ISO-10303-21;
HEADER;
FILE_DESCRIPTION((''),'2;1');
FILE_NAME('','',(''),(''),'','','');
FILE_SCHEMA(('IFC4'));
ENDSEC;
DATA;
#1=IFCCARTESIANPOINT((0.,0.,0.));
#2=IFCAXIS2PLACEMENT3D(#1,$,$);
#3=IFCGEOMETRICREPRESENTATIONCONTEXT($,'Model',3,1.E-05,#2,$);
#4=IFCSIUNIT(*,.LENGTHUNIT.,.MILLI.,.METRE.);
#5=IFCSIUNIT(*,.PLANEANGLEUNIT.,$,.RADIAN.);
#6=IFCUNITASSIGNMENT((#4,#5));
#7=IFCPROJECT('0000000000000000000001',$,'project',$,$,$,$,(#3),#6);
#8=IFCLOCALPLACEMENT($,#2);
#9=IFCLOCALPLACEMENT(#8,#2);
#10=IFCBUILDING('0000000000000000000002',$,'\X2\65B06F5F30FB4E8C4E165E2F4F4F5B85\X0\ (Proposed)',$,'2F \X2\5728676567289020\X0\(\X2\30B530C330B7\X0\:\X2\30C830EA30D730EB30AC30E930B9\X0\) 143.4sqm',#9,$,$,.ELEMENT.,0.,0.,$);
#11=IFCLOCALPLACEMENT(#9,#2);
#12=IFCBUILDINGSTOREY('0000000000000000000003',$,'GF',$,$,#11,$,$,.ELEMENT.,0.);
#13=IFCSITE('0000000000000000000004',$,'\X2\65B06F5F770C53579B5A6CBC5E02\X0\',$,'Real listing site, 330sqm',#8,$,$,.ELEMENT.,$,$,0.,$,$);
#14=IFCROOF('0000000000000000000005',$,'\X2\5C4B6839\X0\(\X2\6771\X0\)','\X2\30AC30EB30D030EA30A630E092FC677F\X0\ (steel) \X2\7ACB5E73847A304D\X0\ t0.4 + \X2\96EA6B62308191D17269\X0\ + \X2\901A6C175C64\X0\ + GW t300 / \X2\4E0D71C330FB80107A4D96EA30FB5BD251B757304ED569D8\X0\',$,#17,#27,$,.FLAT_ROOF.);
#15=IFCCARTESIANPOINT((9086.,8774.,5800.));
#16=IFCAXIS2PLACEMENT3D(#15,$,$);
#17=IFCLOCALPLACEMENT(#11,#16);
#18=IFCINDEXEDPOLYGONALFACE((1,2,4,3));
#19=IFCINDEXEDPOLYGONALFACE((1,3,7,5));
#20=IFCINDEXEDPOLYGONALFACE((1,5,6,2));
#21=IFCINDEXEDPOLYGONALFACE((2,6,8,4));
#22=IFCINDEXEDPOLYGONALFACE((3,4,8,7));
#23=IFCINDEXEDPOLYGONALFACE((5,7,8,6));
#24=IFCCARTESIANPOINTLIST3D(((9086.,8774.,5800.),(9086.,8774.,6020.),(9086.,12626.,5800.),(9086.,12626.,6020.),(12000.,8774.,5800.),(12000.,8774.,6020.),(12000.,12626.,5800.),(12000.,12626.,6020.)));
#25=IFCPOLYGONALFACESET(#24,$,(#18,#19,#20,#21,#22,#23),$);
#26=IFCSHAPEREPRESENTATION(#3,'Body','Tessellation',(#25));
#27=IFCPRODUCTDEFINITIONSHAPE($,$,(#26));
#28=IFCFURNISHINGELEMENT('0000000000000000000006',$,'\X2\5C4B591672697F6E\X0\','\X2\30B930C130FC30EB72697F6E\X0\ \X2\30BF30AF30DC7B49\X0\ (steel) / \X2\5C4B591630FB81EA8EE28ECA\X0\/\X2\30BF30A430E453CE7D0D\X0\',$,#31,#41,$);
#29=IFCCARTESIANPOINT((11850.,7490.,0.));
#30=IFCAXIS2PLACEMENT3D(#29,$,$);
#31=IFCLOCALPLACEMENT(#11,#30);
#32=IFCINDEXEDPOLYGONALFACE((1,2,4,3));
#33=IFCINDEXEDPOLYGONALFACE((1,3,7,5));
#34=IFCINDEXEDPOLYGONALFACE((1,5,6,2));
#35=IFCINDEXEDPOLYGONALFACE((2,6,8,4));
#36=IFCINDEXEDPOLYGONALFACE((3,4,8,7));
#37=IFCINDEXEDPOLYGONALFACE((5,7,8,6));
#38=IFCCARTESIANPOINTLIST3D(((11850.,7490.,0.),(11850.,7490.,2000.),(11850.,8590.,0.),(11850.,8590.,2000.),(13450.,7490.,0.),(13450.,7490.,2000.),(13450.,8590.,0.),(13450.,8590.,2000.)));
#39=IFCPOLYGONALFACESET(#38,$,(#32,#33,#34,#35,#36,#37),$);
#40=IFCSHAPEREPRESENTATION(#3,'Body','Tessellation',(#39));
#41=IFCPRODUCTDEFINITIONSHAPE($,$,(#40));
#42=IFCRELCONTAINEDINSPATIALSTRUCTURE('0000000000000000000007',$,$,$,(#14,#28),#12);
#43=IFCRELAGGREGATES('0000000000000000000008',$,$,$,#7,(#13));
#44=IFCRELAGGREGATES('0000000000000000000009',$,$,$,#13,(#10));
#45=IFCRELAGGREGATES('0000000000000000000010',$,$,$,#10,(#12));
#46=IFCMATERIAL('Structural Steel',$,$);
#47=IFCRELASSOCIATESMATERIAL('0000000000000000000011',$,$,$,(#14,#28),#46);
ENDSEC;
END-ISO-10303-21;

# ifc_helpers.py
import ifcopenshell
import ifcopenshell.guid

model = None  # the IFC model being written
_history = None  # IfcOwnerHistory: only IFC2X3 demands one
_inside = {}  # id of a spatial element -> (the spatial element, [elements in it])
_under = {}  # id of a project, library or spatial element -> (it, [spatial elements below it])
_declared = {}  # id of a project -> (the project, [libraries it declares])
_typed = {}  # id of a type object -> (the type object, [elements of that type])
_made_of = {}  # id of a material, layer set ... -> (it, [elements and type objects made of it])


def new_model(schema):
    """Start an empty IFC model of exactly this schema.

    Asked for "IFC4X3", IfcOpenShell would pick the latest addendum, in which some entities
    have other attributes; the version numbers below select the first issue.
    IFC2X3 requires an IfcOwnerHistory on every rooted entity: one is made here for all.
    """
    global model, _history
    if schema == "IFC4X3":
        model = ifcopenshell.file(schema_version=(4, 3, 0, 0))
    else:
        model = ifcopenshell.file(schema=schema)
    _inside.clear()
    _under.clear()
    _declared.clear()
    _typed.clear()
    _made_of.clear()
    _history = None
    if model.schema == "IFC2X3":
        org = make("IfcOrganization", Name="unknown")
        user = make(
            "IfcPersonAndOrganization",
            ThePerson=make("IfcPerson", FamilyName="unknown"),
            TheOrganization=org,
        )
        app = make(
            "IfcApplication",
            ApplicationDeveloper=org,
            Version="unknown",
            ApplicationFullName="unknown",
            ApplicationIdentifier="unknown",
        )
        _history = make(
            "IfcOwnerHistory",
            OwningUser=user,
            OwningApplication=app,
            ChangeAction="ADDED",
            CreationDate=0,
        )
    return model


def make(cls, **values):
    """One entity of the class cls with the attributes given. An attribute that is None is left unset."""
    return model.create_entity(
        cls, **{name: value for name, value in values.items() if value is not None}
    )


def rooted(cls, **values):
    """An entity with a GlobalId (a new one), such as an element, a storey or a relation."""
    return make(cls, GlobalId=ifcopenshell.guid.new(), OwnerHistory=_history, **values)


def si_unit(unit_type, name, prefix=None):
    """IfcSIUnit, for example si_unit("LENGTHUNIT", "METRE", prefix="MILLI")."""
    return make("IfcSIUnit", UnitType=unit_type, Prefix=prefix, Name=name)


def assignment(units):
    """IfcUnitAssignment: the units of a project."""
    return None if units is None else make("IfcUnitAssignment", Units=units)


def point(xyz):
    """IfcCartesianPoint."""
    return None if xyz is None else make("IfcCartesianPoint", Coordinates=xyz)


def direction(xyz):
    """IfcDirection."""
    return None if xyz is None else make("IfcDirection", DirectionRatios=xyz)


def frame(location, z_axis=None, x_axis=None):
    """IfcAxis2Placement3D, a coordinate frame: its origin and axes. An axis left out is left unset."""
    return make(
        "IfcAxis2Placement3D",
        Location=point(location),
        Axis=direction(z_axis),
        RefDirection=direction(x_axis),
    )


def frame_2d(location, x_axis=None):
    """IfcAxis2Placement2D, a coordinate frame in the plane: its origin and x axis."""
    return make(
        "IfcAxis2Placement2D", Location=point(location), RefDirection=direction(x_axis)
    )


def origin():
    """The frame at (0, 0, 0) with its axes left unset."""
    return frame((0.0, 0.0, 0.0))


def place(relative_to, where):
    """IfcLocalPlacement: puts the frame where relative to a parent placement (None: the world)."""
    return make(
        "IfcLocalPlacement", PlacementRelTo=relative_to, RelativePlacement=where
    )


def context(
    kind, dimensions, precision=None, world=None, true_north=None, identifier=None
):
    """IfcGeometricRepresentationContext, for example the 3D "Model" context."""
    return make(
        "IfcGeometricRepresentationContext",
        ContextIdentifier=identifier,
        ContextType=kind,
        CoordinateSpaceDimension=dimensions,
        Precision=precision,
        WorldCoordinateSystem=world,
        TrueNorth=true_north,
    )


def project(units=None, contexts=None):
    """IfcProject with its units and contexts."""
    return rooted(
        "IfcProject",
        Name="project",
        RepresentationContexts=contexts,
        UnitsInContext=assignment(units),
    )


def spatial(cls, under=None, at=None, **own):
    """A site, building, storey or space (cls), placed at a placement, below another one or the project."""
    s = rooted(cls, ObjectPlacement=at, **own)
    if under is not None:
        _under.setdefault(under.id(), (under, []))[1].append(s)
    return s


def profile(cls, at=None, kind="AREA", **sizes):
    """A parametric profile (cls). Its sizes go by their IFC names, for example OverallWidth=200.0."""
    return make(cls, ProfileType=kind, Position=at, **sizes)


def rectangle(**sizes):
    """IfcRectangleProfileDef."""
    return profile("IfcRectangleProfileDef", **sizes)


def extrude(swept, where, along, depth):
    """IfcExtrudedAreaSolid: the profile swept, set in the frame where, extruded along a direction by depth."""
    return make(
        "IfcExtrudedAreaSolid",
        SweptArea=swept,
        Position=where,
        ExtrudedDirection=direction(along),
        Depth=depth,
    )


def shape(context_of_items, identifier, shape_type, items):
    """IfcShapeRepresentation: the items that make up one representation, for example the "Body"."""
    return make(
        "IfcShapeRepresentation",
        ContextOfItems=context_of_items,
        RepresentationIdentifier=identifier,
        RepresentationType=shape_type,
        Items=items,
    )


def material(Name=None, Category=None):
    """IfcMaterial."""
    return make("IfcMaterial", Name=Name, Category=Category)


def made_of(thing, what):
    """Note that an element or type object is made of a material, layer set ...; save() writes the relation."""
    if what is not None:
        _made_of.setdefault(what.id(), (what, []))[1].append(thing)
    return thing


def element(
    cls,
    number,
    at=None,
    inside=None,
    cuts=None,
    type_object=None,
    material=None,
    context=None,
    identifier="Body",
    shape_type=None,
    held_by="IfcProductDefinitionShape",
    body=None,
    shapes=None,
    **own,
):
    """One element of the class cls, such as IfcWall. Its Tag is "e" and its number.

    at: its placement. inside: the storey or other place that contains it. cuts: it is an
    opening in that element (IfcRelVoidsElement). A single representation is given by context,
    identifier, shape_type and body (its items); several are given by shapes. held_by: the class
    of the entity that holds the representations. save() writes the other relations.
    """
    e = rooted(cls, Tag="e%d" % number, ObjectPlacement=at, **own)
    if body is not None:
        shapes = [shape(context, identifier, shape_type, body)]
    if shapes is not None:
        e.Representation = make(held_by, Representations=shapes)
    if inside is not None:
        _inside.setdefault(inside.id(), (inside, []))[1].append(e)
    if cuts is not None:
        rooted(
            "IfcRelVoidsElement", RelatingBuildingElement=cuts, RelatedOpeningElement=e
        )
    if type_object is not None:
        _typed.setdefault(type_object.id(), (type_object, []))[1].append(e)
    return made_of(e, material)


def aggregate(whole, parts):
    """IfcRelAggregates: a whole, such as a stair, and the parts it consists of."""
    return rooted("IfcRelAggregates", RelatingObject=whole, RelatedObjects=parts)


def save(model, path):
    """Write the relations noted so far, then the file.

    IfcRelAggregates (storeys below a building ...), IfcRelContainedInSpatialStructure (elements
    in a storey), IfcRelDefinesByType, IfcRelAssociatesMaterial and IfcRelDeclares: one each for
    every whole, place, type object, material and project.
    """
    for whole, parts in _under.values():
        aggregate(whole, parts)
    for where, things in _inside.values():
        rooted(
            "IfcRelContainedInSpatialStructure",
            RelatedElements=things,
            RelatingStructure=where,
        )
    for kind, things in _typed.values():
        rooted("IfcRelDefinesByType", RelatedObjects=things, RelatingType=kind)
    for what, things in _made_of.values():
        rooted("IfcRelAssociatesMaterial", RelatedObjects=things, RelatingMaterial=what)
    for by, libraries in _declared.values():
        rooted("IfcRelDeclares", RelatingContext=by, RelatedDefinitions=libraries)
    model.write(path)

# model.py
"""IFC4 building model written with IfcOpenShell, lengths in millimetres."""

from ifc_helpers import new_model, si_unit, frame, frame_2d, origin, place, context, project, spatial, rectangle, extrude, material, element, save


model = new_model("IFC4")

# Units and contexts
model_context = context("Model", 3, precision=1e-05, world=origin())
ifc_project = project(units=[si_unit("LENGTHUNIT", "METRE", prefix="MILLI"), si_unit("PLANEANGLEUNIT", "RADIAN")], contexts=[model_context])

# Site, building, storey
site_placement = place(None, origin())
site = spatial("IfcSite", under=ifc_project, at=site_placement, Name="新潟県南魚沼市", ObjectType="Real listing site, 330sqm", CompositionType="ELEMENT", RefElevation=0.0)
building_placement = place(site_placement, origin())
building = spatial("IfcBuilding", under=site, at=building_placement, Name="新潟・二世帯住宅 (Proposed)", ObjectType="2F 在来木造(サッシ:トリプルガラス) 143.4sqm", CompositionType="ELEMENT", ElevationOfRefHeight=0.0, ElevationOfTerrain=0.0)
storey_placement = place(building_placement, origin())
storey = spatial("IfcBuildingStorey", under=building, at=storey_placement, Name="GF", CompositionType="ELEMENT", Elevation=0.0)

# Roof
ifc_material_1 = material(Name="Structural Steel")
for number, where, name in (
    (1, (9086.0, 8774.0, 5800.0), "屋根(東)"),
):
    element("IfcRoof", number, at=place(storey_placement, frame(where)), inside=storey, material=ifc_material_1, Name=name, Description="ガルバリウム鋼板 (steel) 立平葺き t0.4 + 雪止め金物 + 通気層 + GW t300 / 不燃・耐積雪・寒冷地仕様", PredefinedType="FLAT_ROOF", context=model_context, shape_type="SweptSolid", body=[
        extrude(rectangle(XDim=2914.0, YDim=3852.0, at=frame_2d((1457.0, 1926.0))), frame((9086.0, 8774.0, 5800.0)), (0.0, 0.0, 1.0), 220.0),
    ])

# Furnishing element
furnishing_placement = place(storey_placement, frame((11850.0, 7490.0, 0.0)))
element("IfcFurnishingElement", 2, at=furnishing_placement, inside=storey, material=ifc_material_1, Name="屋外物置", Description="スチール物置 タクボ等 (steel) / 屋外・自転車/タイヤ収納", context=model_context, shape_type="SweptSolid", body=[
    extrude(rectangle(XDim=1600.0, YDim=1100.0, at=frame_2d((800.0, 550.0))), frame((11850.0, 7490.0, 0.0)), (0.0, 0.0, 1.0), 2000.0),
])

save(model, "model.ifc")
